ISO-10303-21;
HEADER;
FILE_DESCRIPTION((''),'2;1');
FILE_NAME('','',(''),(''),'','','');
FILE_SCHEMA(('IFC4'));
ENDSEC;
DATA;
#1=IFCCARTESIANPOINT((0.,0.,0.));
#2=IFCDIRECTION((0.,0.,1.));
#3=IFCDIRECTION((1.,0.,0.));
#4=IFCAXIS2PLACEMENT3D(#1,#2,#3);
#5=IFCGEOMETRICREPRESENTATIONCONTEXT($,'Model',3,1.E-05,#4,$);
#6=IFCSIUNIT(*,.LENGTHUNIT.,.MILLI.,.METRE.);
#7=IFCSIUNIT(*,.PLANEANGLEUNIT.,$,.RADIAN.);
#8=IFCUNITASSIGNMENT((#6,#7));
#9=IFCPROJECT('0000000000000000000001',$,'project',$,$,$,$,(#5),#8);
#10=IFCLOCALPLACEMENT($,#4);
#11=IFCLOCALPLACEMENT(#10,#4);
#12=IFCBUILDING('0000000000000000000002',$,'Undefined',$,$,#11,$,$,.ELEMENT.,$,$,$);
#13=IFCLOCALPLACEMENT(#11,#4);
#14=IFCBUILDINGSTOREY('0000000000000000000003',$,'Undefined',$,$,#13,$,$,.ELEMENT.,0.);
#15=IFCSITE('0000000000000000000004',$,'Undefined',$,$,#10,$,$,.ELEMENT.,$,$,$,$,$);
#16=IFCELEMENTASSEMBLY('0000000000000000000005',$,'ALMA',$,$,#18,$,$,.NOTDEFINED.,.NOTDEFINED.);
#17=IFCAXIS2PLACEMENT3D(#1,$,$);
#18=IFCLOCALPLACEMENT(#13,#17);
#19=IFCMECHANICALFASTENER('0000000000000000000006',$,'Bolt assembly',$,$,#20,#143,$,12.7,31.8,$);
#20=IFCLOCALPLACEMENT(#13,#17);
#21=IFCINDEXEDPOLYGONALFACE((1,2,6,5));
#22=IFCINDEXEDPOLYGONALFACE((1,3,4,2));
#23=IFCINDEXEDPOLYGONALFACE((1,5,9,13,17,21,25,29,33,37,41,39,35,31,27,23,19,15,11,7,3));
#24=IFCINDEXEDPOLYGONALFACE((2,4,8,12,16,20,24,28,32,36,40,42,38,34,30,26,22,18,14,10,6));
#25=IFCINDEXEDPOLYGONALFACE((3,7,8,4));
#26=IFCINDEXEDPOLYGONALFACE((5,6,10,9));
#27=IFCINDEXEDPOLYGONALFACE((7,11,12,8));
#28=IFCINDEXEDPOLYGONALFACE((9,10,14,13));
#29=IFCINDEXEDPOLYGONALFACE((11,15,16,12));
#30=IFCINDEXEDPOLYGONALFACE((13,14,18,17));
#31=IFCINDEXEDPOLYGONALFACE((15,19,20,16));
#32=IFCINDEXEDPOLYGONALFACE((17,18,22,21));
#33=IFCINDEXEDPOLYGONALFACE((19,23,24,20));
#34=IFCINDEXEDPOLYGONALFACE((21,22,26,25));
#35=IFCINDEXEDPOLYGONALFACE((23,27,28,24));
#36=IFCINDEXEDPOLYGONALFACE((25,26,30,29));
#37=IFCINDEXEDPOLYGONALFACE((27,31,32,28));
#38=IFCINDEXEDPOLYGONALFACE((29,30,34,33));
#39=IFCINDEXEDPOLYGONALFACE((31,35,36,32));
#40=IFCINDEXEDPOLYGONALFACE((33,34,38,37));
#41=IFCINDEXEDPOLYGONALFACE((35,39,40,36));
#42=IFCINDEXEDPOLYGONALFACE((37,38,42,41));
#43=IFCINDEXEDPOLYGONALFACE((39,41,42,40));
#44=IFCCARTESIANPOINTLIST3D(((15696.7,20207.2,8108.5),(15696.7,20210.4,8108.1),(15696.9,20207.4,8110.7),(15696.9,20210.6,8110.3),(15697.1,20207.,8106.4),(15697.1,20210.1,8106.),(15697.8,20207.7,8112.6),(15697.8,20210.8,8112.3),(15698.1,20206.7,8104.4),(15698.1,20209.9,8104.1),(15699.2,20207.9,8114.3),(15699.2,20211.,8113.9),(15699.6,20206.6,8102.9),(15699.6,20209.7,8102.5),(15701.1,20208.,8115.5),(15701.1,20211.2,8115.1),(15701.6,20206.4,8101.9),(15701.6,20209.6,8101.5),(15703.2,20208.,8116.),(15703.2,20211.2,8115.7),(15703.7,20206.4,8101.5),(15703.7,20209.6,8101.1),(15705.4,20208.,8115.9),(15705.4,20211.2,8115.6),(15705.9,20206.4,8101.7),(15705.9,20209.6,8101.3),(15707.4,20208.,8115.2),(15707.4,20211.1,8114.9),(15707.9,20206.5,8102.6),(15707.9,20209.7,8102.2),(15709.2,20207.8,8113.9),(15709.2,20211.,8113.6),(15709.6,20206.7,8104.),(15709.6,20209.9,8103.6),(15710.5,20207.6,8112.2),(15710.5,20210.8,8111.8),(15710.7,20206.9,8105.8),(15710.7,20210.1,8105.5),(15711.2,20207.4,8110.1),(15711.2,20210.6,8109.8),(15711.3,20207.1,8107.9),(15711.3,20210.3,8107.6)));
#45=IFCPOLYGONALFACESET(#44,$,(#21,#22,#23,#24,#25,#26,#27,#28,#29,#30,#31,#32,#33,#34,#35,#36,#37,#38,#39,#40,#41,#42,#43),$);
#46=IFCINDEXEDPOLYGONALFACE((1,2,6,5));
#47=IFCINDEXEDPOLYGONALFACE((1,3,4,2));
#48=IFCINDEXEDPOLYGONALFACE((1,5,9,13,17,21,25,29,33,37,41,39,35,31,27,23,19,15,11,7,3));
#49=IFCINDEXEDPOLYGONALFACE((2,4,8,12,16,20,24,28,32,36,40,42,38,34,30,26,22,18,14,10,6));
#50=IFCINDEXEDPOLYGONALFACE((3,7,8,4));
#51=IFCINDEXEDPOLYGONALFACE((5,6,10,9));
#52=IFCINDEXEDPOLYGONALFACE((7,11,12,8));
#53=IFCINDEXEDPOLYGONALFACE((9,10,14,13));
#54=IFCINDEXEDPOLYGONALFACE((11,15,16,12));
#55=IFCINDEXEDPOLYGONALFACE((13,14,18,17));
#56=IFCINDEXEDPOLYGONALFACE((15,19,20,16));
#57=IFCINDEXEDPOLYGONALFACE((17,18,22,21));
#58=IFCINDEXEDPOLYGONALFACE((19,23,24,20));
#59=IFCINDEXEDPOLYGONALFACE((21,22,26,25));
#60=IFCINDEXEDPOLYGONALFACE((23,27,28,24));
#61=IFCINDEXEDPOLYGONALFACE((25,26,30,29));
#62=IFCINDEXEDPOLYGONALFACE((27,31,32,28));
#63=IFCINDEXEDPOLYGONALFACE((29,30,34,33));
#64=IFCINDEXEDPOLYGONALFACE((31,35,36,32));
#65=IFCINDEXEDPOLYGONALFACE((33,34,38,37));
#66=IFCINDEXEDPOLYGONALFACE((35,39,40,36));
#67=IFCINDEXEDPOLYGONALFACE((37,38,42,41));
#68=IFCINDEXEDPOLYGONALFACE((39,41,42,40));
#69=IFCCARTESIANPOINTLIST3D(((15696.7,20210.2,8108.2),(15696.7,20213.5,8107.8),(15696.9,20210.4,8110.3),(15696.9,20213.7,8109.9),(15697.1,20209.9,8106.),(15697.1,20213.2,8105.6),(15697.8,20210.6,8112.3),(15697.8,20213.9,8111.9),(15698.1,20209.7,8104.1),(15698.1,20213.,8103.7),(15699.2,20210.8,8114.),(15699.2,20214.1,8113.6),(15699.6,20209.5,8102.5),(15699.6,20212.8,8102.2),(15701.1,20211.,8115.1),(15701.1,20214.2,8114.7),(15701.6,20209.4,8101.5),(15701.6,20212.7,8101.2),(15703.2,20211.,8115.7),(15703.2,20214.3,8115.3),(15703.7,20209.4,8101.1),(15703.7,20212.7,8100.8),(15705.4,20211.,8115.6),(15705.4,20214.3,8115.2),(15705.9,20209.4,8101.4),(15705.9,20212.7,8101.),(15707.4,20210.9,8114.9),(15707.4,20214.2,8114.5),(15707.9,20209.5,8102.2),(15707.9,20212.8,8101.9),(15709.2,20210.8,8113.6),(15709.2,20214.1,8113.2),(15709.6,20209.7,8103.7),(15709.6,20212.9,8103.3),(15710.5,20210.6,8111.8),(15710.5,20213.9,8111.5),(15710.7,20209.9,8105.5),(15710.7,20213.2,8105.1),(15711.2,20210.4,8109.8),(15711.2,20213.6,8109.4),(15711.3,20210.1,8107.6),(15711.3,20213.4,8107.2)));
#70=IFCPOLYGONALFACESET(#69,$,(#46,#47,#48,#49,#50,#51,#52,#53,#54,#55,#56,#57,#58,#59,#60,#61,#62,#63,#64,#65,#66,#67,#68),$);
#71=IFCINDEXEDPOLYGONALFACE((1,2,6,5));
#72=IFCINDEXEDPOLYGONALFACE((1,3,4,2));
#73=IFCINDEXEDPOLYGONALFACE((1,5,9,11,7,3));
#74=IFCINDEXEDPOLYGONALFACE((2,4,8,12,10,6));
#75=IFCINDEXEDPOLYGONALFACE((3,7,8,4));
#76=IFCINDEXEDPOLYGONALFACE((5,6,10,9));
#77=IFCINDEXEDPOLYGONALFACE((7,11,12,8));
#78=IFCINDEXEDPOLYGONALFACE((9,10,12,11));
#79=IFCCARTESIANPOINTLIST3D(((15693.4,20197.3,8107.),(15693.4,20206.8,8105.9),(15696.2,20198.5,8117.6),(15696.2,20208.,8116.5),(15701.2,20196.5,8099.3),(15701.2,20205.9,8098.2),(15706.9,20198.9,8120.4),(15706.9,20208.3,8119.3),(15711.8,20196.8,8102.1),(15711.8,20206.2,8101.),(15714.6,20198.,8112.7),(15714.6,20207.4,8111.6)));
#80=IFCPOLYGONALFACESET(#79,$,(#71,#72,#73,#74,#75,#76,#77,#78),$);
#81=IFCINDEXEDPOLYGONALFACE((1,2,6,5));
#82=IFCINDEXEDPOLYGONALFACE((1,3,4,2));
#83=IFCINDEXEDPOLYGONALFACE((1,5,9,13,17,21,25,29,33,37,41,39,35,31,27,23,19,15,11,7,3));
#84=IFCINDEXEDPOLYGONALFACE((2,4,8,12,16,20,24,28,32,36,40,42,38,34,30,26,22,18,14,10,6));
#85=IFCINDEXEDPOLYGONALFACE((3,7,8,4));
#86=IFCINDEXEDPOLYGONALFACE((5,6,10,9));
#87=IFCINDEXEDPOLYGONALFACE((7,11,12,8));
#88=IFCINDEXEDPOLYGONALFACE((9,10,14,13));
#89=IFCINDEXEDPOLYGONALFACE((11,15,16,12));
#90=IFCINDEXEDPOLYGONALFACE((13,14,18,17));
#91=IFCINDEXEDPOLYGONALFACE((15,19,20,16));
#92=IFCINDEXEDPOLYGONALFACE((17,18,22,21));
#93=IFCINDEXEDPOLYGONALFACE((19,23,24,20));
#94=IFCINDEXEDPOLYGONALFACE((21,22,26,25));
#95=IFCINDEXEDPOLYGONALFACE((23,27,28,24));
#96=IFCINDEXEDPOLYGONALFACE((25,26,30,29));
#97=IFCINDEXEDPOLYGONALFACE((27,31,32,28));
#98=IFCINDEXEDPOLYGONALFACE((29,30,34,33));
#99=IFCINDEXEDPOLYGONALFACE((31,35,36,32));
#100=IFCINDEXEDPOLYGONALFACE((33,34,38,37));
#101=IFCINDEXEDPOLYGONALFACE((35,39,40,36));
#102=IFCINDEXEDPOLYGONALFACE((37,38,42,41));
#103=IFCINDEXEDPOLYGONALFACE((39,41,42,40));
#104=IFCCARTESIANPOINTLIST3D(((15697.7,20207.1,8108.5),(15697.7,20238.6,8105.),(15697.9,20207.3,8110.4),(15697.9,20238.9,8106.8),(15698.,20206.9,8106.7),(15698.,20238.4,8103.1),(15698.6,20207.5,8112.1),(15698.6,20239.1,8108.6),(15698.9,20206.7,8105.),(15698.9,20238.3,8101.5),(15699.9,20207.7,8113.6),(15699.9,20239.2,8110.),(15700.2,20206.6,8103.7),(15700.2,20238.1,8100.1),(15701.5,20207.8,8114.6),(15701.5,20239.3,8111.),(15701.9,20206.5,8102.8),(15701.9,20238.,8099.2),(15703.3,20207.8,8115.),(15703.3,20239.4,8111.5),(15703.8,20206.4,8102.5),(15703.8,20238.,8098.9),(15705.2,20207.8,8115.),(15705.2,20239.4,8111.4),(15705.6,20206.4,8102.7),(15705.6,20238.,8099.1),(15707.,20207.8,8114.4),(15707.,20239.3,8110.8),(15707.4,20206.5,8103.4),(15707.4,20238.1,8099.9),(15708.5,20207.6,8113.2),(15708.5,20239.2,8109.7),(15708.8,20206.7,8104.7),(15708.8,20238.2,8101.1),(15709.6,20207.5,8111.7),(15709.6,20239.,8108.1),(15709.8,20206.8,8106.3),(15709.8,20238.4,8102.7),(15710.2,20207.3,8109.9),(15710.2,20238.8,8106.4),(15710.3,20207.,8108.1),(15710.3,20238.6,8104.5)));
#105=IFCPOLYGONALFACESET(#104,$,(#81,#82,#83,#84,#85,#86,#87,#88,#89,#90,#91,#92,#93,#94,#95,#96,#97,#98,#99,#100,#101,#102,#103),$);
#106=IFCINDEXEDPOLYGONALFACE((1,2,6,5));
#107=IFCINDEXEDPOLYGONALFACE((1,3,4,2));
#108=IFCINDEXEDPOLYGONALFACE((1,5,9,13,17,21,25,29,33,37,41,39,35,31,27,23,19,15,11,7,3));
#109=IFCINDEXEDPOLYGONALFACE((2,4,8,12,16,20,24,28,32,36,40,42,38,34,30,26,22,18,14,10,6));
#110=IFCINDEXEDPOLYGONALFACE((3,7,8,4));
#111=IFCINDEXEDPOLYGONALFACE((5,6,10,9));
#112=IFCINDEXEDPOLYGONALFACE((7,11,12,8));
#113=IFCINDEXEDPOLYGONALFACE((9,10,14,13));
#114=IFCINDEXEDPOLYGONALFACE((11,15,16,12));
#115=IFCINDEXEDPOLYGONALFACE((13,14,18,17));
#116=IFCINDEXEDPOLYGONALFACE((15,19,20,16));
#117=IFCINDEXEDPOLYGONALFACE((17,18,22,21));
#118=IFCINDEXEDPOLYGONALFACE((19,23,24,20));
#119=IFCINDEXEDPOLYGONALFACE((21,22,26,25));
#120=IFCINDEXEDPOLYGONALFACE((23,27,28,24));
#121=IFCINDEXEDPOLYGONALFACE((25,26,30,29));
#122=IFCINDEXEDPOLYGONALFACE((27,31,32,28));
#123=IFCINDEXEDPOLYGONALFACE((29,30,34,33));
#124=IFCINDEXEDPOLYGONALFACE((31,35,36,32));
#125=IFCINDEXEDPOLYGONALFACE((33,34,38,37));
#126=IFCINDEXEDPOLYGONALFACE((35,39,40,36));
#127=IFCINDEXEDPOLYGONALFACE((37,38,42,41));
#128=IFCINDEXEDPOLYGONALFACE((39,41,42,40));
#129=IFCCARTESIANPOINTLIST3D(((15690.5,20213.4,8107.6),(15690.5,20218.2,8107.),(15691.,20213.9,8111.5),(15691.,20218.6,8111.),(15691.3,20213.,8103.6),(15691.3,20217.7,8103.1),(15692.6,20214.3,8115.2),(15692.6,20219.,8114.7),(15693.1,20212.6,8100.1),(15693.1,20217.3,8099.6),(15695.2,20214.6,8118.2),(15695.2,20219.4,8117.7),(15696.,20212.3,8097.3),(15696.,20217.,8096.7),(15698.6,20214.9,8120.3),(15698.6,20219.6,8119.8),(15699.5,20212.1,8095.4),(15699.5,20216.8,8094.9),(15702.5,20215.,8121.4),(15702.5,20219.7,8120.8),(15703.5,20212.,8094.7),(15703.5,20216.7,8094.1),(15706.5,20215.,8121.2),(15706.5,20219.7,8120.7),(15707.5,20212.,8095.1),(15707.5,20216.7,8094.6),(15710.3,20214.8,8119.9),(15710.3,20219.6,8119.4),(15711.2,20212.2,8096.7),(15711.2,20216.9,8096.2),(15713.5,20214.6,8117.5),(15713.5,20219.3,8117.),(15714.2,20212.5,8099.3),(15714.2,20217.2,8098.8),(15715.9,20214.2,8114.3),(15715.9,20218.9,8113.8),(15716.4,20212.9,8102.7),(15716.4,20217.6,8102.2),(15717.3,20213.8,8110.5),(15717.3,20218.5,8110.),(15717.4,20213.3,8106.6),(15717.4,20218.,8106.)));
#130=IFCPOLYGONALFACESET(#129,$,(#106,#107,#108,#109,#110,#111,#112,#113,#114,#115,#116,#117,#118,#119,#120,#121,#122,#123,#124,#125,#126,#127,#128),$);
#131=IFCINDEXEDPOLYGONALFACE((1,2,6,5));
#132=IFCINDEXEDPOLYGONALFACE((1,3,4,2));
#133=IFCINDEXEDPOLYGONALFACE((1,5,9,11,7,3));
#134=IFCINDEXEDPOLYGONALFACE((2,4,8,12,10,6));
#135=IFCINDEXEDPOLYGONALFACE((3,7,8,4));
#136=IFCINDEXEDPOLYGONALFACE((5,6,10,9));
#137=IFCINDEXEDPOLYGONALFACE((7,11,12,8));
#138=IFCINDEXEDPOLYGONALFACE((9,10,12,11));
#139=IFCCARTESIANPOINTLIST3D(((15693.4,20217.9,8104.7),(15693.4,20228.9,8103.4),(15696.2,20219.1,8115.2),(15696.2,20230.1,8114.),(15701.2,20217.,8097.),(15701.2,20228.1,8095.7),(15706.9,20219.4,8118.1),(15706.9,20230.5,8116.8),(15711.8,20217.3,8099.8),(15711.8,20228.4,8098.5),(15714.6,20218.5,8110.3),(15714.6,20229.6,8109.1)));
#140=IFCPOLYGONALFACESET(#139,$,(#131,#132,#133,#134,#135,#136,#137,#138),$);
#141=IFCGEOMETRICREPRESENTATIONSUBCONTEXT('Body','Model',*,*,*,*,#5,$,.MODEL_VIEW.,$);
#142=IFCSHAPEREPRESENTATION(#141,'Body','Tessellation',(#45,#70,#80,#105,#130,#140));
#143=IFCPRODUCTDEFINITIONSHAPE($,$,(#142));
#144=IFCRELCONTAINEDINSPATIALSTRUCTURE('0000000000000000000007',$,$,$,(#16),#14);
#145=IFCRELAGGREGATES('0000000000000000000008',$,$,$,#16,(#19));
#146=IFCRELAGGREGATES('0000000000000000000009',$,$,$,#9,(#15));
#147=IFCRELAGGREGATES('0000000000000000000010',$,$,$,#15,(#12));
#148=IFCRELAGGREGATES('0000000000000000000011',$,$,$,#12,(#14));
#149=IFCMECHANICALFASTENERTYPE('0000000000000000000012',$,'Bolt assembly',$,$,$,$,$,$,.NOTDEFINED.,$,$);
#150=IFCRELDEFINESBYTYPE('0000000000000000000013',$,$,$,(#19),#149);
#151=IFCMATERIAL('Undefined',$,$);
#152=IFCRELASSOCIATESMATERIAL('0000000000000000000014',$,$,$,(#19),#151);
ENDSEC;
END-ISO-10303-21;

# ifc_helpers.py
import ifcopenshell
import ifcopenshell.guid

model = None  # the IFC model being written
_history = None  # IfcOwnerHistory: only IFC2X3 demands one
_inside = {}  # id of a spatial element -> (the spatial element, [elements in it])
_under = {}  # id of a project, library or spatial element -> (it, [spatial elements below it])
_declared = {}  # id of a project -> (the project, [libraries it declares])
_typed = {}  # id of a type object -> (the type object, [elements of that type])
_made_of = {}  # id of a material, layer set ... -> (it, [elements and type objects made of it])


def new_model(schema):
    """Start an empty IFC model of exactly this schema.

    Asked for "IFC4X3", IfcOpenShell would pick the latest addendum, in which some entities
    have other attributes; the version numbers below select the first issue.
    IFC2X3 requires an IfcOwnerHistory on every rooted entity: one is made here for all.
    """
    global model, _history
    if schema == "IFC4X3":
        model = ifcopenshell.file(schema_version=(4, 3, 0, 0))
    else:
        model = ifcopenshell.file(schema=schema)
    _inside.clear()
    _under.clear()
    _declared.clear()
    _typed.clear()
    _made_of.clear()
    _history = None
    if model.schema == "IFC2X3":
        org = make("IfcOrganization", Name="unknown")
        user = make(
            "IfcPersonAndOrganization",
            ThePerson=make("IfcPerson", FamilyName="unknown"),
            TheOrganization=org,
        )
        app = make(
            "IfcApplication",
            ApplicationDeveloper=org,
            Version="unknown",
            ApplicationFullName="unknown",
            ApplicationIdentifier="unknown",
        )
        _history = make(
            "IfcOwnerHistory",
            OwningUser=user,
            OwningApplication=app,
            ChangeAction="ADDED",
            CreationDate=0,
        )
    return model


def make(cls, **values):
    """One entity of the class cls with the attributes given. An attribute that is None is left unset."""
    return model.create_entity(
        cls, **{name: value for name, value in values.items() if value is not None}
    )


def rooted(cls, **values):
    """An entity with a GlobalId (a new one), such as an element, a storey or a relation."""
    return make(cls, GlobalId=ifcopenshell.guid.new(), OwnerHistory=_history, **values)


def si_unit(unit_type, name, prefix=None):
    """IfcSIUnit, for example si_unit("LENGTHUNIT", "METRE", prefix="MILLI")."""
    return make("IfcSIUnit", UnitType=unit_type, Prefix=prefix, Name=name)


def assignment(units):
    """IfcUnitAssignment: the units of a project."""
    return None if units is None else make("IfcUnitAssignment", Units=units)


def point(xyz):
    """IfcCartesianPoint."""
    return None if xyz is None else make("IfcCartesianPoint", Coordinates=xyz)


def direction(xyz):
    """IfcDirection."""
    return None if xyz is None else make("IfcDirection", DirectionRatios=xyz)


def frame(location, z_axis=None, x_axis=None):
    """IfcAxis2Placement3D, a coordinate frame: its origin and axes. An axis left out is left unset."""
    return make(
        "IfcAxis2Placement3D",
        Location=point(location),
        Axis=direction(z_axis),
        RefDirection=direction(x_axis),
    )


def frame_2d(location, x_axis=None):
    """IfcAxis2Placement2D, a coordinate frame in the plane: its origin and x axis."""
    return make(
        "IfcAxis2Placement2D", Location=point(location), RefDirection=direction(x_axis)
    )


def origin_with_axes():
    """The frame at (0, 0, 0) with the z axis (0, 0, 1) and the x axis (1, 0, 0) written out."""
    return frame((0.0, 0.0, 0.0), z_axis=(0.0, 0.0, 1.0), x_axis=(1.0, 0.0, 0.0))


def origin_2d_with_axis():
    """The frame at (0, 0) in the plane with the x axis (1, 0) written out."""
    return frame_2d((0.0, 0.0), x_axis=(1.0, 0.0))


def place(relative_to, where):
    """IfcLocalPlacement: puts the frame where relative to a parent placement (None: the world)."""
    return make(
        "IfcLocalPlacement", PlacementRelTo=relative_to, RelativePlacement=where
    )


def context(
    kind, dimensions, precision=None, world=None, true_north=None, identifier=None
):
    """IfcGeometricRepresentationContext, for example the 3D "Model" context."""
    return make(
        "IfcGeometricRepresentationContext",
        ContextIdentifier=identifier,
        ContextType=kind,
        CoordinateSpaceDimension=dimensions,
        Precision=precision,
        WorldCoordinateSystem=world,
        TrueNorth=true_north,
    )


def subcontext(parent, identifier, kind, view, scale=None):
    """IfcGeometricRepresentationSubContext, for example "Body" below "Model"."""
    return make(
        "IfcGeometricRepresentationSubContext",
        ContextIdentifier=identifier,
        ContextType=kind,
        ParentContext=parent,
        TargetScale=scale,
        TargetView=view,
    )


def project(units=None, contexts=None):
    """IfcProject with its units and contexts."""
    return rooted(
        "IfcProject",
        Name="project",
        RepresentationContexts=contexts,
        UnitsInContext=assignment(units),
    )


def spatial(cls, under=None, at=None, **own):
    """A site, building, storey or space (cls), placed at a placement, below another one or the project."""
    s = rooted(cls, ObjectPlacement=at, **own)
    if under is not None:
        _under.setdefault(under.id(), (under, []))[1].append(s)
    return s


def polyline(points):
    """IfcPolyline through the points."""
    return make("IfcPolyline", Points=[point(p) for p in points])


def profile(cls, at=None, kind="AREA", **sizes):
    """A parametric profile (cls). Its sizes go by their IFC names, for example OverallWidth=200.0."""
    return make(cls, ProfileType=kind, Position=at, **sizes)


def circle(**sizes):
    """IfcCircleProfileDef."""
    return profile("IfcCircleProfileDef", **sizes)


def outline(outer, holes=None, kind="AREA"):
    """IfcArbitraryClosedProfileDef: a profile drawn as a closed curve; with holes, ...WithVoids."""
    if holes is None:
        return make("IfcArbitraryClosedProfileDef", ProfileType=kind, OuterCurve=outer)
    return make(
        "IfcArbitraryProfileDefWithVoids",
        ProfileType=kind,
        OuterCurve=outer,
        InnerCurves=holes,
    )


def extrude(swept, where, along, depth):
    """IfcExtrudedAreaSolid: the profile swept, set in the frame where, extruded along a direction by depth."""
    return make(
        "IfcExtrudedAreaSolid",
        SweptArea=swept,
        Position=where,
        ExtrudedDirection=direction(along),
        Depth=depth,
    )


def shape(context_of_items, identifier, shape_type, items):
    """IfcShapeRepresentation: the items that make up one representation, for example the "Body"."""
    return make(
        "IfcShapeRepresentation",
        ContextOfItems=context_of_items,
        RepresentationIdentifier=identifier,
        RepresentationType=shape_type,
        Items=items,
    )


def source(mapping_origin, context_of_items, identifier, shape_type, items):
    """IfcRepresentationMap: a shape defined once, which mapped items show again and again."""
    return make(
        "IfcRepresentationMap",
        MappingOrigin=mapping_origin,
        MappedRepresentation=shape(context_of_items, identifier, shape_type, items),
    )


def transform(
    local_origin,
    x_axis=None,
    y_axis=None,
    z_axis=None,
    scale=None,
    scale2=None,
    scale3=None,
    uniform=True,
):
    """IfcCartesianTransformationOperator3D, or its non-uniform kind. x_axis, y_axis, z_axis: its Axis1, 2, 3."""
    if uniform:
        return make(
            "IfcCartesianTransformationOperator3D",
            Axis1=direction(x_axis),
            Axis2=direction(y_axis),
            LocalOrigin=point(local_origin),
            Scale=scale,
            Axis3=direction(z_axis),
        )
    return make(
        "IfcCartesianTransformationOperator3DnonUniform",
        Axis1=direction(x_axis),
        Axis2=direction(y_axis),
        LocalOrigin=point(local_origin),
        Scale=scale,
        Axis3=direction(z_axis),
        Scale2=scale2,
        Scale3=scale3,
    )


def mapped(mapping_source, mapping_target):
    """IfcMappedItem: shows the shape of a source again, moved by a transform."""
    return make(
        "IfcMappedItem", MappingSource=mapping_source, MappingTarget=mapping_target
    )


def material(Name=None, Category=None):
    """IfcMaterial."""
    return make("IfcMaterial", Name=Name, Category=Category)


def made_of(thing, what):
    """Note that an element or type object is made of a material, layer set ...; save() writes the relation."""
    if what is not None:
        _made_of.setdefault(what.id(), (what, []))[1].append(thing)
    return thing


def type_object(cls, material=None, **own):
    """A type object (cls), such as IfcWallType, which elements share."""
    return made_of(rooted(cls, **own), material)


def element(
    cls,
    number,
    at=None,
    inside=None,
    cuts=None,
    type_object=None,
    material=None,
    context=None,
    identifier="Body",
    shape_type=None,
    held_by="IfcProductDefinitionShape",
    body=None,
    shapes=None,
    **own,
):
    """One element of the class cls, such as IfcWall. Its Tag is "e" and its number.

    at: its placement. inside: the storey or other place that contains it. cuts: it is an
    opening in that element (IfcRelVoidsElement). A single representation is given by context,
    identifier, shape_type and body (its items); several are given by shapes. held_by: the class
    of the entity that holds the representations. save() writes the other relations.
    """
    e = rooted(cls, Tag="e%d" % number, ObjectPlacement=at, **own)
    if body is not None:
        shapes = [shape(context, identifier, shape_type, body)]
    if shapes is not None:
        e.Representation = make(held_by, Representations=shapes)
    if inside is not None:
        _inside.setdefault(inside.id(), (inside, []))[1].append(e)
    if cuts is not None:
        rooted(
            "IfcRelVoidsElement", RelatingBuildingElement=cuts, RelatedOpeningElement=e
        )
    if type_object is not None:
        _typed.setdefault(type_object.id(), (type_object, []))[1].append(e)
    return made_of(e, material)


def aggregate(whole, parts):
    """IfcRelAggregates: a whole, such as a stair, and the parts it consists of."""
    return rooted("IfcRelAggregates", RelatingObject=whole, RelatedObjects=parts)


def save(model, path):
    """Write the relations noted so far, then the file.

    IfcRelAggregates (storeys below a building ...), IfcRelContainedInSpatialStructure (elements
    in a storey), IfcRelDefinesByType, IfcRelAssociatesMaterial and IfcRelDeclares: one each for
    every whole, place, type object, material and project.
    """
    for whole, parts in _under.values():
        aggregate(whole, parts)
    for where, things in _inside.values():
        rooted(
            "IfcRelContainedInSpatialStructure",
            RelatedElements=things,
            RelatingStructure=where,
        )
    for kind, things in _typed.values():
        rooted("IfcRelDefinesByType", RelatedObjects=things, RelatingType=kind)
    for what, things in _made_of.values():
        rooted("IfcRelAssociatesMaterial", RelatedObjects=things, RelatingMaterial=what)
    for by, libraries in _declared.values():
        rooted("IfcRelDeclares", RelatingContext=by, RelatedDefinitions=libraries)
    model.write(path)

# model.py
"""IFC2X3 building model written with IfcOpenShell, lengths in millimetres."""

from ifc_helpers import new_model, si_unit, frame, origin_with_axes, origin_2d_with_axis, place, context, subcontext, project, spatial, polyline, circle, outline, extrude, source, transform, mapped, material, type_object, element, aggregate, save


model = new_model("IFC2X3")

# Units and contexts
model_context = context("Model", 3, precision=1e-05, world=origin_with_axes())
body_context = subcontext(model_context, "Body", "Model", "MODEL_VIEW")
ifc_project = project(units=[si_unit("LENGTHUNIT", "METRE", prefix="MILLI"), si_unit("PLANEANGLEUNIT", "RADIAN")], contexts=[model_context])

# Site, building, storey
site_placement = place(None, origin_with_axes())
site = spatial("IfcSite", under=ifc_project, at=site_placement, Name="Undefined", CompositionType="ELEMENT")
building_placement = place(site_placement, origin_with_axes())
building = spatial("IfcBuilding", under=site, at=building_placement, Name="Undefined", CompositionType="ELEMENT")
storey_placement = place(building_placement, origin_with_axes())
storey = spatial("IfcBuildingStorey", under=building, at=storey_placement, Name="Undefined", CompositionType="ELEMENT", Elevation=0.0)

# Element assembly
assembly_1_placement = place(storey_placement, origin_with_axes())
assembly_1 = element("IfcElementAssembly", 1, at=assembly_1_placement, inside=storey, Name="ALMA", AssemblyPlace="NOTDEFINED", PredefinedType="NOTDEFINED")

# Mechanical fastener
ifc_material_1 = material(Name="Undefined")
mechanical_fastener_type = type_object("IfcMechanicalFastenerType", Name="Bolt assembly")
shared_shape_1 = source(origin_with_axes(), body_context, "Body", "SweptSolid", [
    extrude(circle(Radius=7.3, at=origin_2d_with_axis()), frame((0.0, 0.1, 0.0), z_axis=(0.0, 1.0, 0.0), x_axis=(1.0, 0.0, 0.0)), (0.0, 0.0, 1.0), 3.2),
    extrude(circle(Radius=7.3, at=origin_2d_with_axis()), frame((0.0, 3.1, 0.0), z_axis=(0.0, 1.0, 0.0), x_axis=(1.0, 0.0, 0.0)), (0.0, 0.0, 1.0), 3.3),
    extrude(outline(polyline([(9.5, -5.5), (9.5, 5.5), (0.0, 11.0), (-9.5, 5.5), (-9.5, -5.5), (0.0, -11.0), (9.5, -5.5)])), frame((0.0, -9.5, 0.0), z_axis=(0.0, 1.0, 0.0), x_axis=(1.0, 0.0, 0.0)), (0.0, 0.0, 1.0), 9.5),
    extrude(circle(Radius=6.3, at=origin_2d_with_axis()), frame((0.0, 0.0, 0.0), z_axis=(0.0, 1.0, 0.0), x_axis=(1.0, 0.0, 0.0)), (0.0, 0.0, 1.0), 31.8),
    extrude(circle(Radius=13.5, at=origin_2d_with_axis()), frame((0.0, 6.4, 0.0), z_axis=(0.0, 1.0, 0.0), x_axis=(1.0, 0.0, 0.0)), (0.0, 0.0, 1.0), 4.8),
    extrude(outline(polyline([(9.5, -5.5), (9.5, 5.5), (0.0, 11.0), (-9.5, 5.5), (-9.5, -5.5), (0.0, -11.0), (9.5, -5.5)])), frame((0.0, 11.2, 0.0), z_axis=(0.0, 1.0, 0.0), x_axis=(1.0, 0.0, 0.0)), (0.0, 0.0, 1.0), 11.1),
])
mechanical_fastener_1_placement = place(assembly_1_placement, frame((15704.0, 20207.1, 8108.8), z_axis=(-0.707107, 0.079651, 0.702606), x_axis=(0.707107, 0.079651, 0.702606)))
mechanical_fastener_1 = element("IfcMechanicalFastener", 2, at=mechanical_fastener_1_placement, type_object=mechanical_fastener_type, material=ifc_material_1, Name="Bolt assembly", NominalDiameter=12.7, NominalLength=31.8, context=body_context, shape_type="MappedRepresentation", body=[
    mapped(shared_shape_1, transform((0.0, 0.0, 0.0))),
])
aggregate(assembly_1, [mechanical_fastener_1])

save(model, "model.ifc")
